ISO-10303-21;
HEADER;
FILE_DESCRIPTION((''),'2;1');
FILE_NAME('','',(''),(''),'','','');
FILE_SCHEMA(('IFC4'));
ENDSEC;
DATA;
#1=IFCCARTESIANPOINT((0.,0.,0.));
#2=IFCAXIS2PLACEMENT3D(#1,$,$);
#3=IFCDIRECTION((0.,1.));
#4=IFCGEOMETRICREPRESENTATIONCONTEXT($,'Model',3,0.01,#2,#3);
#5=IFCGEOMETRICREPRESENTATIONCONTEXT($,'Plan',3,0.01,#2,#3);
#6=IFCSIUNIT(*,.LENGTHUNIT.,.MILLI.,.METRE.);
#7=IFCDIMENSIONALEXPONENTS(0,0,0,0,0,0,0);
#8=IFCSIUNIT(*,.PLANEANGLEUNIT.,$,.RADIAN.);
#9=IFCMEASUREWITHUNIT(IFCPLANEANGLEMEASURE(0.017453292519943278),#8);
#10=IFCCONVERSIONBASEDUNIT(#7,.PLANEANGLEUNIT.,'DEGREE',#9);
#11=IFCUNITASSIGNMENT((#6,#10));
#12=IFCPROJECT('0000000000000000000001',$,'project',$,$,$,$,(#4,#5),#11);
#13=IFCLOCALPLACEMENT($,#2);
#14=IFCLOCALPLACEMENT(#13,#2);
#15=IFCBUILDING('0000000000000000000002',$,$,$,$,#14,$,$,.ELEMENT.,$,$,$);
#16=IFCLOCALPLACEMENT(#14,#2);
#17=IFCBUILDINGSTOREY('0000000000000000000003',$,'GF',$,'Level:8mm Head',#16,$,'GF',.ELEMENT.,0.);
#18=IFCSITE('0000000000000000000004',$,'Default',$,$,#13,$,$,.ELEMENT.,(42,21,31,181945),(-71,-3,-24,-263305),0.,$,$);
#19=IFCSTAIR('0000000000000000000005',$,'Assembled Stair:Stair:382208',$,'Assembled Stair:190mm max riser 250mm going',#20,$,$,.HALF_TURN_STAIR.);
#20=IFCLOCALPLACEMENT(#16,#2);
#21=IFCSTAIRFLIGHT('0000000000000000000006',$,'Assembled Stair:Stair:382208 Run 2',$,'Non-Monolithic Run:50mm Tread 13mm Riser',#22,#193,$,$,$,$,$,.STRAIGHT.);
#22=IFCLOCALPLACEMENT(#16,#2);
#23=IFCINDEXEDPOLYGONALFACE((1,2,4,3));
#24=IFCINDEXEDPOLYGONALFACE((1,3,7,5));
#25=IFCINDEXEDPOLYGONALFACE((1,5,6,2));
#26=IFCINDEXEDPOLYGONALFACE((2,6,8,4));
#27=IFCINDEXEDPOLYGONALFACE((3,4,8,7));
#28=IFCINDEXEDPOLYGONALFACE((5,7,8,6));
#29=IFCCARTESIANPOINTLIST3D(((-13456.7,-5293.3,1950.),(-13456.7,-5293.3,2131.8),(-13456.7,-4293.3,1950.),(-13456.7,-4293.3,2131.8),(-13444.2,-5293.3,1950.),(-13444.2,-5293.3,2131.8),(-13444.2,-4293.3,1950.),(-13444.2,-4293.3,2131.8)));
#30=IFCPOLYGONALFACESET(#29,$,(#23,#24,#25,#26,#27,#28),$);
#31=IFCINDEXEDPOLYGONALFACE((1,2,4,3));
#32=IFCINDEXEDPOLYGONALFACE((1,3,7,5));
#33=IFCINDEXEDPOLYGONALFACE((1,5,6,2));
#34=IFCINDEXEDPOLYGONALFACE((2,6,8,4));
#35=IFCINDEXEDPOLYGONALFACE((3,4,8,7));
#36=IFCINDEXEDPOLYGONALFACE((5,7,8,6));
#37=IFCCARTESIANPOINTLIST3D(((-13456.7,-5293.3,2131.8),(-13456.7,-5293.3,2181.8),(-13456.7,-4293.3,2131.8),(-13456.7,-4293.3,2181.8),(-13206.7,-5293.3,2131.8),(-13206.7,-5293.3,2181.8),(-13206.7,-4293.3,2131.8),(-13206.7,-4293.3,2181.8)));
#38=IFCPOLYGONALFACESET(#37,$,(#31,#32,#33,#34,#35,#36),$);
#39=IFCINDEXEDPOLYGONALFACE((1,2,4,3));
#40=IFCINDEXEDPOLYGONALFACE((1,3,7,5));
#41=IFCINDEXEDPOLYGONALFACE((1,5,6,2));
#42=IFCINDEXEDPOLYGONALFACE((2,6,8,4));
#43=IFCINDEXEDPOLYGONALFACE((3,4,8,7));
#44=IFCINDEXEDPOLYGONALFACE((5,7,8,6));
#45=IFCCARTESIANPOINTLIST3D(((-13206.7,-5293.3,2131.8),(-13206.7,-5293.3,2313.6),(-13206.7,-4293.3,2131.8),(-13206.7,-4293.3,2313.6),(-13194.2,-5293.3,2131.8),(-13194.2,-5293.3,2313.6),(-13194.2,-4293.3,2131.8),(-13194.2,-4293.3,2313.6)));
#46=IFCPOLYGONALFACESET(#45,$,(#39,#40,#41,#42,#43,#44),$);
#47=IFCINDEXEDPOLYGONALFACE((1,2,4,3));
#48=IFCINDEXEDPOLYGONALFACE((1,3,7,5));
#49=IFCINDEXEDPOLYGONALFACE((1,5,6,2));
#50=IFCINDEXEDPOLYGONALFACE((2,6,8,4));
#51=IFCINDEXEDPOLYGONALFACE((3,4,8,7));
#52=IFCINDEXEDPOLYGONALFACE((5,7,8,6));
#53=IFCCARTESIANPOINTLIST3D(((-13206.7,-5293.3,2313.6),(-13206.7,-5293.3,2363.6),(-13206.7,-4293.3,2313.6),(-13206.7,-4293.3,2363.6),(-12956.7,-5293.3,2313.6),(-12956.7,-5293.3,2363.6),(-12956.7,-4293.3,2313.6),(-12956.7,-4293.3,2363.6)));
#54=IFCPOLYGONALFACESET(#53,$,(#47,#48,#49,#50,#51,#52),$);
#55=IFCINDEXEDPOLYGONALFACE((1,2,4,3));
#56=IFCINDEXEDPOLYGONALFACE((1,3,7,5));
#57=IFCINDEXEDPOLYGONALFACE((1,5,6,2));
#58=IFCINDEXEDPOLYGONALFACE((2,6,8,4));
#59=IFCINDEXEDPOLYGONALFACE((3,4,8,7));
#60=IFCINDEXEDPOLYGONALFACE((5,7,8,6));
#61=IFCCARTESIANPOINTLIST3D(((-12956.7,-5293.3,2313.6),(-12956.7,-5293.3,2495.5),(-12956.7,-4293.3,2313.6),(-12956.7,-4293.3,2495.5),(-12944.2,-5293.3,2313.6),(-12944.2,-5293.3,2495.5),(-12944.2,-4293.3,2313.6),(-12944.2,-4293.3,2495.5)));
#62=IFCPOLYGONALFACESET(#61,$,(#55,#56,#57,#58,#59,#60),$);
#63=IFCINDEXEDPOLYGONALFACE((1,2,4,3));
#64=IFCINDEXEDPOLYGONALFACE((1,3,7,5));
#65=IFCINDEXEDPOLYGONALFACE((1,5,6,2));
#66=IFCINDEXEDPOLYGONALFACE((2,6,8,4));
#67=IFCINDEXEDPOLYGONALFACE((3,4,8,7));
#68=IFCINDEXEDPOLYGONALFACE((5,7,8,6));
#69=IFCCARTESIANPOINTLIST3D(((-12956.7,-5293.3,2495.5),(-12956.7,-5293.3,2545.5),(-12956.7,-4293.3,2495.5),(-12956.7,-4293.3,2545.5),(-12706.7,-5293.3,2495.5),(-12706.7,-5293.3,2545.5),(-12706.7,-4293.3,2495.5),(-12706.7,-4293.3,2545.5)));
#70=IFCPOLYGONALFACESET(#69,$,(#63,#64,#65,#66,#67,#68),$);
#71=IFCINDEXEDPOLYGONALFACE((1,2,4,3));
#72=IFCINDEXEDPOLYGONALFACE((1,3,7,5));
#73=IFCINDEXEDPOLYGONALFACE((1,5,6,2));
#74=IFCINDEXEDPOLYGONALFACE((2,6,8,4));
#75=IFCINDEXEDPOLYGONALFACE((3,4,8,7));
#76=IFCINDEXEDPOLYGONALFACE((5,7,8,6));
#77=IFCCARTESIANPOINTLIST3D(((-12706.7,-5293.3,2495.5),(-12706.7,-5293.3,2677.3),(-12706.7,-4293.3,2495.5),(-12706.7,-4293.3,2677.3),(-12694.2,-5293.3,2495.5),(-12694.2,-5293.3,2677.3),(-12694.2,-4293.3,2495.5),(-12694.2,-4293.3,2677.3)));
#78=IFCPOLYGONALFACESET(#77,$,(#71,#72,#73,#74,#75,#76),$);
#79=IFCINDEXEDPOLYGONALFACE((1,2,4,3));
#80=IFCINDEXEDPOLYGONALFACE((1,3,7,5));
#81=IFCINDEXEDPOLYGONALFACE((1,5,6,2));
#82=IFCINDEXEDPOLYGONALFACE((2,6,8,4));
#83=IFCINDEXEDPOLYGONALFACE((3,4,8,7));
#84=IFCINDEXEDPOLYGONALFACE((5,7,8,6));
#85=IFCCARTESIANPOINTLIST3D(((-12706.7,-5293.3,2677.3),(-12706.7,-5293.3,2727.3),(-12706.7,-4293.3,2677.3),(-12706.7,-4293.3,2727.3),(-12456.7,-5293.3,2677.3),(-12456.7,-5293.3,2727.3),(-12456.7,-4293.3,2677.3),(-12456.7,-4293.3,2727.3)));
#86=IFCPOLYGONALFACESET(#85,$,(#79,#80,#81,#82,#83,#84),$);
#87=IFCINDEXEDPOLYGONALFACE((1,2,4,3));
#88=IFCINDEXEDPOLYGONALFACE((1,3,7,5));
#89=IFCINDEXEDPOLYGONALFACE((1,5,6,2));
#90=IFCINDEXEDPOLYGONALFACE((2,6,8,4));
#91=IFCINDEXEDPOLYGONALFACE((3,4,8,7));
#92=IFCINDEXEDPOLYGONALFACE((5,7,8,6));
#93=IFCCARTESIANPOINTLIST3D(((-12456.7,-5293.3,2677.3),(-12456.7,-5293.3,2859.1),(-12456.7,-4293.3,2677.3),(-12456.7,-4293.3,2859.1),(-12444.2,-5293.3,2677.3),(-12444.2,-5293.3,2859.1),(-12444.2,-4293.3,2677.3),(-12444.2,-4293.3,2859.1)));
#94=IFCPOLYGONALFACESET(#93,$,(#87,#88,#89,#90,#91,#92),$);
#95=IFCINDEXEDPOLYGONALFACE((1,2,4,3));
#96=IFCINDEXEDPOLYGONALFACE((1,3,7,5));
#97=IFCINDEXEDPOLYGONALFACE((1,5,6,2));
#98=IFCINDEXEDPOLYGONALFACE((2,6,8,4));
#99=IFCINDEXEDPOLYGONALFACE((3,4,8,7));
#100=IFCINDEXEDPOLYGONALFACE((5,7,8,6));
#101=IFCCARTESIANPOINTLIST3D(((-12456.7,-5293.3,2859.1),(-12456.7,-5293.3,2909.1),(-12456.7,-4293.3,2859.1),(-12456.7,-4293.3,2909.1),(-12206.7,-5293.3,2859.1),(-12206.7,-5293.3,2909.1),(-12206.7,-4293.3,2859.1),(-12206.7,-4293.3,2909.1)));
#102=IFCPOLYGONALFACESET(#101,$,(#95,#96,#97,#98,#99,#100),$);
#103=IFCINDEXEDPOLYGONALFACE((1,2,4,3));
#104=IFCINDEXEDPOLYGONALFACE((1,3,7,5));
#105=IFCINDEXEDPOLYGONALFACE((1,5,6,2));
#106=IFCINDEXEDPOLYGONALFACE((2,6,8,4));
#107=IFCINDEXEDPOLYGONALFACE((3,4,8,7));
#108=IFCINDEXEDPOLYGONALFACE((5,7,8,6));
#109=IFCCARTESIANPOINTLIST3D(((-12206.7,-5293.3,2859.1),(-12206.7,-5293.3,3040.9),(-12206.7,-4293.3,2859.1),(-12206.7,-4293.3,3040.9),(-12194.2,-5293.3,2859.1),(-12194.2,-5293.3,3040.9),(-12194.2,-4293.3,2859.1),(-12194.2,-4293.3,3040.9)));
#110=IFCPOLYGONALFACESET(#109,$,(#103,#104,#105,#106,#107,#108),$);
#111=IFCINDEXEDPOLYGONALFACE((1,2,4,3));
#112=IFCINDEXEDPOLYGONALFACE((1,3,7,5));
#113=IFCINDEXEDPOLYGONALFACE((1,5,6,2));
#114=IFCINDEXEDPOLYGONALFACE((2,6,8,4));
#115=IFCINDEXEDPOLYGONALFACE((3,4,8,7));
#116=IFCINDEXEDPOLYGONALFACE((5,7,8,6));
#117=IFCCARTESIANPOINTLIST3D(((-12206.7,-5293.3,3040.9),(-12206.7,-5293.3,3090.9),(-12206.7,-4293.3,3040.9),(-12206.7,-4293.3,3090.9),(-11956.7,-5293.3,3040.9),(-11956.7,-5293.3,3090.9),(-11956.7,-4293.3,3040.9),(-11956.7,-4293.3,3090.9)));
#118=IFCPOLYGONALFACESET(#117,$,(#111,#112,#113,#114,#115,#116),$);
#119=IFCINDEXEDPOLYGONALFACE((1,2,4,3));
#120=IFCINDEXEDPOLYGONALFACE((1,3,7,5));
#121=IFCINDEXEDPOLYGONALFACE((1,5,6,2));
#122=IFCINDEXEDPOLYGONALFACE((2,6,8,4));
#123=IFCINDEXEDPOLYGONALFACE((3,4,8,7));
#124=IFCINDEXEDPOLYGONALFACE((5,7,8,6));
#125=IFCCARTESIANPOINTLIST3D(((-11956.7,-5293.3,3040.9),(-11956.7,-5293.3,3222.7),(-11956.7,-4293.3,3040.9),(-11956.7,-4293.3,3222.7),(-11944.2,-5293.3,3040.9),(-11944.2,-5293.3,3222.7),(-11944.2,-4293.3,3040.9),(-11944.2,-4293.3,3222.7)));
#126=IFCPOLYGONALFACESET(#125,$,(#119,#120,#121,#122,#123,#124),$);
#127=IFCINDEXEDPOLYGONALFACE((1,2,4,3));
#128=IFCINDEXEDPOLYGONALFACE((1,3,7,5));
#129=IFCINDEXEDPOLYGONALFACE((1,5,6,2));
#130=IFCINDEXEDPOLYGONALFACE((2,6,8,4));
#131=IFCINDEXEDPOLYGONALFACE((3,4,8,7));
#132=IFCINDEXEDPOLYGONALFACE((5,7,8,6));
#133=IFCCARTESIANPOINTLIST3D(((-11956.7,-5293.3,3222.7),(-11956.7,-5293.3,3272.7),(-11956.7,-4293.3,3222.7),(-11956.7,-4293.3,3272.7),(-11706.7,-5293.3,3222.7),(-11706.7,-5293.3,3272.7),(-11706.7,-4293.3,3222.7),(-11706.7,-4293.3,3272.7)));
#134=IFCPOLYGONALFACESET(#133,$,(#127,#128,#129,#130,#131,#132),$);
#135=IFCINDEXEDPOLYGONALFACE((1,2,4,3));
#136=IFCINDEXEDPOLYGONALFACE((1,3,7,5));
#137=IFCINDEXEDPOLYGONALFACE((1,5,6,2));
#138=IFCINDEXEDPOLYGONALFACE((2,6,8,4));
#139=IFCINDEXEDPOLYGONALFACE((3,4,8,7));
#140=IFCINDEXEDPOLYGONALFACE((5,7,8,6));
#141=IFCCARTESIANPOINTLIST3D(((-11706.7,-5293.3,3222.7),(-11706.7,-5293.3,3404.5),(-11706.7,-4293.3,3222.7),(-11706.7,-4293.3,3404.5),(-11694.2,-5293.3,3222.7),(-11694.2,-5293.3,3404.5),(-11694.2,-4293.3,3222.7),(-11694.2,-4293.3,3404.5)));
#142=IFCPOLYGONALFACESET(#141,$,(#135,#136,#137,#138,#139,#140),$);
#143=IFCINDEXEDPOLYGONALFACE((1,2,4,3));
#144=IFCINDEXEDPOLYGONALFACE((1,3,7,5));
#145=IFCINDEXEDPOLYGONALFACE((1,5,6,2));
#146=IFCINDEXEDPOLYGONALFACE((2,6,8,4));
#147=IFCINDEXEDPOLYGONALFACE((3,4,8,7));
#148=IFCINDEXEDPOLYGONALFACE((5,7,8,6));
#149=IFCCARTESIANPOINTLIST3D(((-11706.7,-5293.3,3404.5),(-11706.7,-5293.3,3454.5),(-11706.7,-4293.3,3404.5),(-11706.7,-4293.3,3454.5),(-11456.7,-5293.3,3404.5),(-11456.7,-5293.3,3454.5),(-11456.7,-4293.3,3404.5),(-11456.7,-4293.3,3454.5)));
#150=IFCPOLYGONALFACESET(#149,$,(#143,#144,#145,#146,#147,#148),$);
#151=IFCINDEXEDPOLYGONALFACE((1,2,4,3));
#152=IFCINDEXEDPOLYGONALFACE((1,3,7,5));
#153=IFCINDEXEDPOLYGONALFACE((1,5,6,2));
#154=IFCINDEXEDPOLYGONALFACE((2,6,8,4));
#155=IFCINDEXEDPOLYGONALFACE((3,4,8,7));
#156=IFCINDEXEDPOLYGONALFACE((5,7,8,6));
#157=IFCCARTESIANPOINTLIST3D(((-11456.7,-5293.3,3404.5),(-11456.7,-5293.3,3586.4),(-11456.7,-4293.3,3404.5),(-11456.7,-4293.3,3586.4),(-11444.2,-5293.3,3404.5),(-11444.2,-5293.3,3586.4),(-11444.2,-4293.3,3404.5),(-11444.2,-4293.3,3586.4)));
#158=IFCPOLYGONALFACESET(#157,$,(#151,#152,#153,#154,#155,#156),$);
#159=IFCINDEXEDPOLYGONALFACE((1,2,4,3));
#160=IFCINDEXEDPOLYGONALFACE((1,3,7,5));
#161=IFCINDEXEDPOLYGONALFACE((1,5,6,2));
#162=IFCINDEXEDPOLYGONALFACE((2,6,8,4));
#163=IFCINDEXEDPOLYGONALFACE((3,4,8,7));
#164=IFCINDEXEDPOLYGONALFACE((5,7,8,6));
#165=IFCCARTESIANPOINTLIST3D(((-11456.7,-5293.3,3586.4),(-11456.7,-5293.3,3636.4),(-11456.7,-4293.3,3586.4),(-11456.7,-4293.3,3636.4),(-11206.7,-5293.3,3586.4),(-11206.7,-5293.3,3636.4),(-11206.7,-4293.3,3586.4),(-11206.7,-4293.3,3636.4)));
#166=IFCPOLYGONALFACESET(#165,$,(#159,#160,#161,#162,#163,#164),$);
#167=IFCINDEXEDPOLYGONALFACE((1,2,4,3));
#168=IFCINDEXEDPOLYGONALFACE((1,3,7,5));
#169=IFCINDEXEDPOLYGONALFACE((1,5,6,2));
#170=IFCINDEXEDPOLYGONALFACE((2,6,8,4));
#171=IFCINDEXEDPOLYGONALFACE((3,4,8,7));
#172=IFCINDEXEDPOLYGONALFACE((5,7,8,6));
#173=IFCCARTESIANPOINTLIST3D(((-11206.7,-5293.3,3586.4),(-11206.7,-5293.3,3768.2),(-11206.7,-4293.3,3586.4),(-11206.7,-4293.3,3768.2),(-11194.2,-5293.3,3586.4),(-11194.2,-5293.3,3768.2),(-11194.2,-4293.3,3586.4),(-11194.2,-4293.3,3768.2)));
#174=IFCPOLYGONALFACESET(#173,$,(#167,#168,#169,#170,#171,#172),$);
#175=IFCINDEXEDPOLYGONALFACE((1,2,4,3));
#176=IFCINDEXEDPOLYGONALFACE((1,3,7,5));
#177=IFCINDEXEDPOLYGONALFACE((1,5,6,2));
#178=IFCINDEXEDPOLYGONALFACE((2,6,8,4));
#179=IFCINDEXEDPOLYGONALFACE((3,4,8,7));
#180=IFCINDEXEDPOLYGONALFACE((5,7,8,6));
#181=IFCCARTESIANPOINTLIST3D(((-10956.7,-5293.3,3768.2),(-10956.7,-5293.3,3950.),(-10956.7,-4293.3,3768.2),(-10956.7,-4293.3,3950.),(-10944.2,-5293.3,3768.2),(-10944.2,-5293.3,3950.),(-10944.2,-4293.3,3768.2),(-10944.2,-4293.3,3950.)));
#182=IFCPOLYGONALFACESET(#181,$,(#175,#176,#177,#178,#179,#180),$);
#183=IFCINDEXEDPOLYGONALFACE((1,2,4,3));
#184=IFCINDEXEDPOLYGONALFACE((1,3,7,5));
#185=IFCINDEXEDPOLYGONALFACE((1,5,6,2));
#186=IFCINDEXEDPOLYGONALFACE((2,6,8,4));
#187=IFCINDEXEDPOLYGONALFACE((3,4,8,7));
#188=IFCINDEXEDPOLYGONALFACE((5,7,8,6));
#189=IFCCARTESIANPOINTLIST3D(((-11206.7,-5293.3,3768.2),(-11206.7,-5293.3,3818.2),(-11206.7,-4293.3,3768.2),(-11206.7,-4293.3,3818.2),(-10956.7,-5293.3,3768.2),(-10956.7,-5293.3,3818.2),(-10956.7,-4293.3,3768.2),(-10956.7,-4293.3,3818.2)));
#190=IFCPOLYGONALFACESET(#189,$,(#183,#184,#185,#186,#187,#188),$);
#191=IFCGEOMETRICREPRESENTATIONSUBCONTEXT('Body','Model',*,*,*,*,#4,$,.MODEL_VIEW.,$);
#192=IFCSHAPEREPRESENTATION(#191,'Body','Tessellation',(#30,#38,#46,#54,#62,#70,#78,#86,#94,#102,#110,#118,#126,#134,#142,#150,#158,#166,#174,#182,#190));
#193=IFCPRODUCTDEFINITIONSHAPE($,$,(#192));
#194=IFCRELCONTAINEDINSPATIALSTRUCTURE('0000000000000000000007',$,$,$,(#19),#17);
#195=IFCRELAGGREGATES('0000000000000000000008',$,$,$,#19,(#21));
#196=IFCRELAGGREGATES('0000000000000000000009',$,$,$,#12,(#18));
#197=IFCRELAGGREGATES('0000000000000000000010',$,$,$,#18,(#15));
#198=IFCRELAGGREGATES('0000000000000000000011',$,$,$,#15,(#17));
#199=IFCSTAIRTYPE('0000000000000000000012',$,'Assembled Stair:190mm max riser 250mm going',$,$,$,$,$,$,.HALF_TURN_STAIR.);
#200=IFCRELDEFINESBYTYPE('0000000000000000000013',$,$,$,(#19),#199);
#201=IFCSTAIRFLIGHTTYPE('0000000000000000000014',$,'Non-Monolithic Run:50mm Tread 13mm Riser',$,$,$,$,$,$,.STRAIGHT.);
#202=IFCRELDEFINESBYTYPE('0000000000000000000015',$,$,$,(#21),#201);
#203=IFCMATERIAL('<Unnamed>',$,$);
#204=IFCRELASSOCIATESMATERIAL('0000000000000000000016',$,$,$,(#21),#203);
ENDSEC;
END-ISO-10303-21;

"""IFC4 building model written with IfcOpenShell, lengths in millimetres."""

from ifc_helpers import new_model, entity, si_unit, converted_unit, direction, frame, origin, place, context, subcontext, project, spatial, indexed_curve, outline, extrude, material, type_object, element, aggregate, save


model = new_model("IFC4")

# Units and contexts
model_context = context("Model", 3, precision=0.01, world=origin(), true_north=direction((0.0, 1.0)))
plan_context = context("Plan", 3, precision=0.01, world=origin(), true_north=direction((0.0, 1.0)))
body_context = subcontext(model_context, "Body", "Model", "MODEL_VIEW")
ifc_project = project(units=[si_unit("LENGTHUNIT", "METRE", prefix="MILLI"), converted_unit("PLANEANGLEUNIT", "DEGREE", entity("IfcPlaneAngleMeasure", 0.017453292519943278), si_unit("PLANEANGLEUNIT", "RADIAN"), dimensions=[0, 0, 0, 0, 0, 0, 0])], contexts=[model_context, plan_context])

# Site, building, storey
site_placement = place(None, origin())
site = spatial("IfcSite", under=ifc_project, at=site_placement, Name="Default", CompositionType="ELEMENT", RefLatitude=(42, 21, 31, 181945), RefLongitude=(-71, -3, -24, -263305), RefElevation=0.0)
building_placement = place(site_placement, origin())
building = spatial("IfcBuilding", under=site, at=building_placement, CompositionType="ELEMENT")
storey_placement = place(building_placement, origin())
storey = spatial("IfcBuildingStorey", under=building, at=storey_placement, Name="GF", ObjectType="Level:8mm Head", LongName="GF", CompositionType="ELEMENT", Elevation=0.0)

# Stair
stair_type = type_object("IfcStairType", Name="Assembled Stair:190mm max riser 250mm going", PredefinedType="HALF_TURN_STAIR")
stair_placement = place(storey_placement, origin())
stair = element("IfcStair", 1, at=stair_placement, inside=storey, type_object=stair_type, Name="Assembled Stair:Stair:382208", ObjectType="Assembled Stair:190mm max riser 250mm going", PredefinedType="HALF_TURN_STAIR")
ifc_material_1 = material(Name="<Unnamed>")

# Stair flight
stair_flight_type = type_object("IfcStairFlightType", Name="Non-Monolithic Run:50mm Tread 13mm Riser", PredefinedType="STRAIGHT")
stair_flight_1_placement = place(stair_placement, origin())
stair_flight_1 = element("IfcStairFlight", 2, at=stair_flight_1_placement, type_object=stair_flight_type, material=ifc_material_1, Name="Assembled Stair:Stair:382208 Run 2", ObjectType="Non-Monolithic Run:50mm Tread 13mm Riser", PredefinedType="STRAIGHT", context=body_context, shape_type="SweptSolid", body=[
    extrude(outline(indexed_curve([(-500.0, -6.3), (500.0, -6.3), (500.0, 6.2), (-500.0, 6.2), (-500.0, -6.3)], self_intersect=False)), frame((-13450.4, -4793.3, 1950.0), z_axis=(0.0, 0.0, 1.0), x_axis=(0.0, 1.0, 0.0)), (0.0, 0.0, 1.0), 181.8),
    extrude(outline(indexed_curve([(-125.0, -500.0), (125.0, -500.0), (125.0, 500.0), (-125.0, 500.0), (-125.0, -500.0)], self_intersect=False)), frame((-13331.7, -4793.3, 2131.8), z_axis=(0.0, 0.0, 1.0), x_axis=(-1.0, 0.0, 0.0)), (0.0, 0.0, 1.0), 50.0),
    extrude(outline(indexed_curve([(-500.0, -6.2), (500.0, -6.2), (500.0, 6.2), (-500.0, 6.2), (-500.0, -6.2)], self_intersect=False)), frame((-13200.4, -4793.3, 2131.8), z_axis=(0.0, 0.0, 1.0), x_axis=(0.0, 1.0, 0.0)), (0.0, 0.0, 1.0), 181.8),
    extrude(outline(indexed_curve([(-125.0, -500.0), (125.0, -500.0), (125.0, 500.0), (-125.0, 500.0), (-125.0, -500.0)], self_intersect=False)), frame((-13081.7, -4793.3, 2313.6), z_axis=(0.0, 0.0, 1.0), x_axis=(-1.0, 0.0, 0.0)), (0.0, 0.0, 1.0), 50.0),
    extrude(outline(indexed_curve([(-500.0, -6.2), (500.0, -6.2), (500.0, 6.3), (-500.0, 6.3), (-500.0, -6.2)], self_intersect=False)), frame((-12950.4, -4793.3, 2313.6), z_axis=(0.0, 0.0, 1.0), x_axis=(0.0, 1.0, 0.0)), (0.0, 0.0, 1.0), 181.8),
    extrude(outline(indexed_curve([(-125.0, -500.0), (125.0, -500.0), (125.0, 500.0), (-125.0, 500.0), (-125.0, -500.0)], self_intersect=False)), frame((-12831.7, -4793.3, 2495.5), z_axis=(0.0, 0.0, 1.0), x_axis=(-1.0, 0.0, 0.0)), (0.0, 0.0, 1.0), 50.0),
    extrude(outline(indexed_curve([(-500.0, -6.2), (500.0, -6.2), (500.0, 6.2), (-500.0, 6.2), (-500.0, -6.2)], self_intersect=False)), frame((-12700.4, -4793.3, 2495.5), z_axis=(0.0, 0.0, 1.0), x_axis=(0.0, 1.0, 0.0)), (0.0, 0.0, 1.0), 181.8),
    extrude(outline(indexed_curve([(-125.0, -500.0), (125.0, -500.0), (125.0, 500.0), (-125.0, 500.0), (-125.0, -500.0)], self_intersect=False)), frame((-12581.7, -4793.3, 2677.3), z_axis=(0.0, 0.0, 1.0), x_axis=(-1.0, 0.0, 0.0)), (0.0, 0.0, 1.0), 50.0),
    extrude(outline(indexed_curve([(-500.0, -6.2), (500.0, -6.2), (500.0, 6.3), (-500.0, 6.3), (-500.0, -6.2)], self_intersect=False)), frame((-12450.4, -4793.3, 2677.3), z_axis=(0.0, 0.0, 1.0), x_axis=(0.0, 1.0, 0.0)), (0.0, 0.0, 1.0), 181.8),
    extrude(outline(indexed_curve([(-125.0, -500.0), (125.0, -500.0), (125.0, 500.0), (-125.0, 500.0), (-125.0, -500.0)], self_intersect=False)), frame((-12331.7, -4793.3, 2859.1), z_axis=(0.0, 0.0, 1.0), x_axis=(-1.0, 0.0, 0.0)), (0.0, 0.0, 1.0), 50.0),
    extrude(outline(indexed_curve([(-500.0, -6.2), (500.0, -6.2), (500.0, 6.2), (-500.0, 6.2), (-500.0, -6.2)], self_intersect=False)), frame((-12200.4, -4793.3, 2859.1), z_axis=(0.0, 0.0, 1.0), x_axis=(0.0, 1.0, 0.0)), (0.0, 0.0, 1.0), 181.8),
    extrude(outline(indexed_curve([(-125.0, -500.0), (125.0, -500.0), (125.0, 500.0), (-125.0, 500.0), (-125.0, -500.0)], self_intersect=False)), frame((-12081.7, -4793.3, 3040.9), z_axis=(0.0, 0.0, 1.0), x_axis=(-1.0, 0.0, 0.0)), (0.0, 0.0, 1.0), 50.0),
    extrude(outline(indexed_curve([(-500.0, -6.2), (500.0, -6.2), (500.0, 6.3), (-500.0, 6.3), (-500.0, -6.2)], self_intersect=False)), frame((-11950.4, -4793.3, 3040.9), z_axis=(0.0, 0.0, 1.0), x_axis=(0.0, 1.0, 0.0)), (0.0, 0.0, 1.0), 181.8),
    extrude(outline(indexed_curve([(-125.0, -500.0), (125.0, -500.0), (125.0, 500.0), (-125.0, 500.0), (-125.0, -500.0)], self_intersect=False)), frame((-11831.7, -4793.3, 3222.7), z_axis=(0.0, 0.0, 1.0), x_axis=(-1.0, 0.0, 0.0)), (0.0, 0.0, 1.0), 50.0),
    extrude(outline(indexed_curve([(-500.0, -6.2), (500.0, -6.2), (500.0, 6.2), (-500.0, 6.2), (-500.0, -6.2)], self_intersect=False)), frame((-11700.4, -4793.3, 3222.7), z_axis=(0.0, 0.0, 1.0), x_axis=(0.0, 1.0, 0.0)), (0.0, 0.0, 1.0), 181.8),
    extrude(outline(indexed_curve([(-125.0, -500.0), (125.0, -500.0), (125.0, 500.0), (-125.0, 500.0), (-125.0, -500.0)], self_intersect=False)), frame((-11581.7, -4793.3, 3404.5), z_axis=(0.0, 0.0, 1.0), x_axis=(-1.0, 0.0, 0.0)), (0.0, 0.0, 1.0), 50.0),
    extrude(outline(indexed_curve([(-500.0, -6.2), (500.0, -6.2), (500.0, 6.3), (-500.0, 6.3), (-500.0, -6.2)], self_intersect=False)), frame((-11450.4, -4793.3, 3404.5), z_axis=(0.0, 0.0, 1.0), x_axis=(0.0, 1.0, 0.0)), (0.0, 0.0, 1.0), 181.8),
    extrude(outline(indexed_curve([(-125.0, -500.0), (125.0, -500.0), (125.0, 500.0), (-125.0, 500.0), (-125.0, -500.0)], self_intersect=False)), frame((-11331.7, -4793.3, 3586.4), z_axis=(0.0, 0.0, 1.0), x_axis=(-1.0, 0.0, 0.0)), (0.0, 0.0, 1.0), 50.0),
    extrude(outline(indexed_curve([(-500.0, -6.2), (500.0, -6.2), (500.0, 6.2), (-500.0, 6.2), (-500.0, -6.2)], self_intersect=False)), frame((-11200.4, -4793.3, 3586.4), z_axis=(0.0, 0.0, 1.0), x_axis=(0.0, 1.0, 0.0)), (0.0, 0.0, 1.0), 181.8),
    extrude(outline(indexed_curve([(-500.0, -6.2), (500.0, -6.2), (500.0, 6.3), (-500.0, 6.3), (-500.0, -6.2)], self_intersect=False)), frame((-10950.4, -4793.3, 3768.2), z_axis=(0.0, 0.0, 1.0), x_axis=(0.0, 1.0, 0.0)), (0.0, 0.0, 1.0), 181.8),
    extrude(outline(indexed_curve([(-125.0, -500.0), (125.0, -500.0), (125.0, 500.0), (-125.0, 500.0), (-125.0, -500.0)], self_intersect=False)), frame((-11081.7, -4793.3, 3768.2), z_axis=(0.0, 0.0, 1.0), x_axis=(-1.0, 0.0, 0.0)), (0.0, 0.0, 1.0), 50.0),
])
aggregate(stair, [stair_flight_1])

save(model, "model.ifc")
